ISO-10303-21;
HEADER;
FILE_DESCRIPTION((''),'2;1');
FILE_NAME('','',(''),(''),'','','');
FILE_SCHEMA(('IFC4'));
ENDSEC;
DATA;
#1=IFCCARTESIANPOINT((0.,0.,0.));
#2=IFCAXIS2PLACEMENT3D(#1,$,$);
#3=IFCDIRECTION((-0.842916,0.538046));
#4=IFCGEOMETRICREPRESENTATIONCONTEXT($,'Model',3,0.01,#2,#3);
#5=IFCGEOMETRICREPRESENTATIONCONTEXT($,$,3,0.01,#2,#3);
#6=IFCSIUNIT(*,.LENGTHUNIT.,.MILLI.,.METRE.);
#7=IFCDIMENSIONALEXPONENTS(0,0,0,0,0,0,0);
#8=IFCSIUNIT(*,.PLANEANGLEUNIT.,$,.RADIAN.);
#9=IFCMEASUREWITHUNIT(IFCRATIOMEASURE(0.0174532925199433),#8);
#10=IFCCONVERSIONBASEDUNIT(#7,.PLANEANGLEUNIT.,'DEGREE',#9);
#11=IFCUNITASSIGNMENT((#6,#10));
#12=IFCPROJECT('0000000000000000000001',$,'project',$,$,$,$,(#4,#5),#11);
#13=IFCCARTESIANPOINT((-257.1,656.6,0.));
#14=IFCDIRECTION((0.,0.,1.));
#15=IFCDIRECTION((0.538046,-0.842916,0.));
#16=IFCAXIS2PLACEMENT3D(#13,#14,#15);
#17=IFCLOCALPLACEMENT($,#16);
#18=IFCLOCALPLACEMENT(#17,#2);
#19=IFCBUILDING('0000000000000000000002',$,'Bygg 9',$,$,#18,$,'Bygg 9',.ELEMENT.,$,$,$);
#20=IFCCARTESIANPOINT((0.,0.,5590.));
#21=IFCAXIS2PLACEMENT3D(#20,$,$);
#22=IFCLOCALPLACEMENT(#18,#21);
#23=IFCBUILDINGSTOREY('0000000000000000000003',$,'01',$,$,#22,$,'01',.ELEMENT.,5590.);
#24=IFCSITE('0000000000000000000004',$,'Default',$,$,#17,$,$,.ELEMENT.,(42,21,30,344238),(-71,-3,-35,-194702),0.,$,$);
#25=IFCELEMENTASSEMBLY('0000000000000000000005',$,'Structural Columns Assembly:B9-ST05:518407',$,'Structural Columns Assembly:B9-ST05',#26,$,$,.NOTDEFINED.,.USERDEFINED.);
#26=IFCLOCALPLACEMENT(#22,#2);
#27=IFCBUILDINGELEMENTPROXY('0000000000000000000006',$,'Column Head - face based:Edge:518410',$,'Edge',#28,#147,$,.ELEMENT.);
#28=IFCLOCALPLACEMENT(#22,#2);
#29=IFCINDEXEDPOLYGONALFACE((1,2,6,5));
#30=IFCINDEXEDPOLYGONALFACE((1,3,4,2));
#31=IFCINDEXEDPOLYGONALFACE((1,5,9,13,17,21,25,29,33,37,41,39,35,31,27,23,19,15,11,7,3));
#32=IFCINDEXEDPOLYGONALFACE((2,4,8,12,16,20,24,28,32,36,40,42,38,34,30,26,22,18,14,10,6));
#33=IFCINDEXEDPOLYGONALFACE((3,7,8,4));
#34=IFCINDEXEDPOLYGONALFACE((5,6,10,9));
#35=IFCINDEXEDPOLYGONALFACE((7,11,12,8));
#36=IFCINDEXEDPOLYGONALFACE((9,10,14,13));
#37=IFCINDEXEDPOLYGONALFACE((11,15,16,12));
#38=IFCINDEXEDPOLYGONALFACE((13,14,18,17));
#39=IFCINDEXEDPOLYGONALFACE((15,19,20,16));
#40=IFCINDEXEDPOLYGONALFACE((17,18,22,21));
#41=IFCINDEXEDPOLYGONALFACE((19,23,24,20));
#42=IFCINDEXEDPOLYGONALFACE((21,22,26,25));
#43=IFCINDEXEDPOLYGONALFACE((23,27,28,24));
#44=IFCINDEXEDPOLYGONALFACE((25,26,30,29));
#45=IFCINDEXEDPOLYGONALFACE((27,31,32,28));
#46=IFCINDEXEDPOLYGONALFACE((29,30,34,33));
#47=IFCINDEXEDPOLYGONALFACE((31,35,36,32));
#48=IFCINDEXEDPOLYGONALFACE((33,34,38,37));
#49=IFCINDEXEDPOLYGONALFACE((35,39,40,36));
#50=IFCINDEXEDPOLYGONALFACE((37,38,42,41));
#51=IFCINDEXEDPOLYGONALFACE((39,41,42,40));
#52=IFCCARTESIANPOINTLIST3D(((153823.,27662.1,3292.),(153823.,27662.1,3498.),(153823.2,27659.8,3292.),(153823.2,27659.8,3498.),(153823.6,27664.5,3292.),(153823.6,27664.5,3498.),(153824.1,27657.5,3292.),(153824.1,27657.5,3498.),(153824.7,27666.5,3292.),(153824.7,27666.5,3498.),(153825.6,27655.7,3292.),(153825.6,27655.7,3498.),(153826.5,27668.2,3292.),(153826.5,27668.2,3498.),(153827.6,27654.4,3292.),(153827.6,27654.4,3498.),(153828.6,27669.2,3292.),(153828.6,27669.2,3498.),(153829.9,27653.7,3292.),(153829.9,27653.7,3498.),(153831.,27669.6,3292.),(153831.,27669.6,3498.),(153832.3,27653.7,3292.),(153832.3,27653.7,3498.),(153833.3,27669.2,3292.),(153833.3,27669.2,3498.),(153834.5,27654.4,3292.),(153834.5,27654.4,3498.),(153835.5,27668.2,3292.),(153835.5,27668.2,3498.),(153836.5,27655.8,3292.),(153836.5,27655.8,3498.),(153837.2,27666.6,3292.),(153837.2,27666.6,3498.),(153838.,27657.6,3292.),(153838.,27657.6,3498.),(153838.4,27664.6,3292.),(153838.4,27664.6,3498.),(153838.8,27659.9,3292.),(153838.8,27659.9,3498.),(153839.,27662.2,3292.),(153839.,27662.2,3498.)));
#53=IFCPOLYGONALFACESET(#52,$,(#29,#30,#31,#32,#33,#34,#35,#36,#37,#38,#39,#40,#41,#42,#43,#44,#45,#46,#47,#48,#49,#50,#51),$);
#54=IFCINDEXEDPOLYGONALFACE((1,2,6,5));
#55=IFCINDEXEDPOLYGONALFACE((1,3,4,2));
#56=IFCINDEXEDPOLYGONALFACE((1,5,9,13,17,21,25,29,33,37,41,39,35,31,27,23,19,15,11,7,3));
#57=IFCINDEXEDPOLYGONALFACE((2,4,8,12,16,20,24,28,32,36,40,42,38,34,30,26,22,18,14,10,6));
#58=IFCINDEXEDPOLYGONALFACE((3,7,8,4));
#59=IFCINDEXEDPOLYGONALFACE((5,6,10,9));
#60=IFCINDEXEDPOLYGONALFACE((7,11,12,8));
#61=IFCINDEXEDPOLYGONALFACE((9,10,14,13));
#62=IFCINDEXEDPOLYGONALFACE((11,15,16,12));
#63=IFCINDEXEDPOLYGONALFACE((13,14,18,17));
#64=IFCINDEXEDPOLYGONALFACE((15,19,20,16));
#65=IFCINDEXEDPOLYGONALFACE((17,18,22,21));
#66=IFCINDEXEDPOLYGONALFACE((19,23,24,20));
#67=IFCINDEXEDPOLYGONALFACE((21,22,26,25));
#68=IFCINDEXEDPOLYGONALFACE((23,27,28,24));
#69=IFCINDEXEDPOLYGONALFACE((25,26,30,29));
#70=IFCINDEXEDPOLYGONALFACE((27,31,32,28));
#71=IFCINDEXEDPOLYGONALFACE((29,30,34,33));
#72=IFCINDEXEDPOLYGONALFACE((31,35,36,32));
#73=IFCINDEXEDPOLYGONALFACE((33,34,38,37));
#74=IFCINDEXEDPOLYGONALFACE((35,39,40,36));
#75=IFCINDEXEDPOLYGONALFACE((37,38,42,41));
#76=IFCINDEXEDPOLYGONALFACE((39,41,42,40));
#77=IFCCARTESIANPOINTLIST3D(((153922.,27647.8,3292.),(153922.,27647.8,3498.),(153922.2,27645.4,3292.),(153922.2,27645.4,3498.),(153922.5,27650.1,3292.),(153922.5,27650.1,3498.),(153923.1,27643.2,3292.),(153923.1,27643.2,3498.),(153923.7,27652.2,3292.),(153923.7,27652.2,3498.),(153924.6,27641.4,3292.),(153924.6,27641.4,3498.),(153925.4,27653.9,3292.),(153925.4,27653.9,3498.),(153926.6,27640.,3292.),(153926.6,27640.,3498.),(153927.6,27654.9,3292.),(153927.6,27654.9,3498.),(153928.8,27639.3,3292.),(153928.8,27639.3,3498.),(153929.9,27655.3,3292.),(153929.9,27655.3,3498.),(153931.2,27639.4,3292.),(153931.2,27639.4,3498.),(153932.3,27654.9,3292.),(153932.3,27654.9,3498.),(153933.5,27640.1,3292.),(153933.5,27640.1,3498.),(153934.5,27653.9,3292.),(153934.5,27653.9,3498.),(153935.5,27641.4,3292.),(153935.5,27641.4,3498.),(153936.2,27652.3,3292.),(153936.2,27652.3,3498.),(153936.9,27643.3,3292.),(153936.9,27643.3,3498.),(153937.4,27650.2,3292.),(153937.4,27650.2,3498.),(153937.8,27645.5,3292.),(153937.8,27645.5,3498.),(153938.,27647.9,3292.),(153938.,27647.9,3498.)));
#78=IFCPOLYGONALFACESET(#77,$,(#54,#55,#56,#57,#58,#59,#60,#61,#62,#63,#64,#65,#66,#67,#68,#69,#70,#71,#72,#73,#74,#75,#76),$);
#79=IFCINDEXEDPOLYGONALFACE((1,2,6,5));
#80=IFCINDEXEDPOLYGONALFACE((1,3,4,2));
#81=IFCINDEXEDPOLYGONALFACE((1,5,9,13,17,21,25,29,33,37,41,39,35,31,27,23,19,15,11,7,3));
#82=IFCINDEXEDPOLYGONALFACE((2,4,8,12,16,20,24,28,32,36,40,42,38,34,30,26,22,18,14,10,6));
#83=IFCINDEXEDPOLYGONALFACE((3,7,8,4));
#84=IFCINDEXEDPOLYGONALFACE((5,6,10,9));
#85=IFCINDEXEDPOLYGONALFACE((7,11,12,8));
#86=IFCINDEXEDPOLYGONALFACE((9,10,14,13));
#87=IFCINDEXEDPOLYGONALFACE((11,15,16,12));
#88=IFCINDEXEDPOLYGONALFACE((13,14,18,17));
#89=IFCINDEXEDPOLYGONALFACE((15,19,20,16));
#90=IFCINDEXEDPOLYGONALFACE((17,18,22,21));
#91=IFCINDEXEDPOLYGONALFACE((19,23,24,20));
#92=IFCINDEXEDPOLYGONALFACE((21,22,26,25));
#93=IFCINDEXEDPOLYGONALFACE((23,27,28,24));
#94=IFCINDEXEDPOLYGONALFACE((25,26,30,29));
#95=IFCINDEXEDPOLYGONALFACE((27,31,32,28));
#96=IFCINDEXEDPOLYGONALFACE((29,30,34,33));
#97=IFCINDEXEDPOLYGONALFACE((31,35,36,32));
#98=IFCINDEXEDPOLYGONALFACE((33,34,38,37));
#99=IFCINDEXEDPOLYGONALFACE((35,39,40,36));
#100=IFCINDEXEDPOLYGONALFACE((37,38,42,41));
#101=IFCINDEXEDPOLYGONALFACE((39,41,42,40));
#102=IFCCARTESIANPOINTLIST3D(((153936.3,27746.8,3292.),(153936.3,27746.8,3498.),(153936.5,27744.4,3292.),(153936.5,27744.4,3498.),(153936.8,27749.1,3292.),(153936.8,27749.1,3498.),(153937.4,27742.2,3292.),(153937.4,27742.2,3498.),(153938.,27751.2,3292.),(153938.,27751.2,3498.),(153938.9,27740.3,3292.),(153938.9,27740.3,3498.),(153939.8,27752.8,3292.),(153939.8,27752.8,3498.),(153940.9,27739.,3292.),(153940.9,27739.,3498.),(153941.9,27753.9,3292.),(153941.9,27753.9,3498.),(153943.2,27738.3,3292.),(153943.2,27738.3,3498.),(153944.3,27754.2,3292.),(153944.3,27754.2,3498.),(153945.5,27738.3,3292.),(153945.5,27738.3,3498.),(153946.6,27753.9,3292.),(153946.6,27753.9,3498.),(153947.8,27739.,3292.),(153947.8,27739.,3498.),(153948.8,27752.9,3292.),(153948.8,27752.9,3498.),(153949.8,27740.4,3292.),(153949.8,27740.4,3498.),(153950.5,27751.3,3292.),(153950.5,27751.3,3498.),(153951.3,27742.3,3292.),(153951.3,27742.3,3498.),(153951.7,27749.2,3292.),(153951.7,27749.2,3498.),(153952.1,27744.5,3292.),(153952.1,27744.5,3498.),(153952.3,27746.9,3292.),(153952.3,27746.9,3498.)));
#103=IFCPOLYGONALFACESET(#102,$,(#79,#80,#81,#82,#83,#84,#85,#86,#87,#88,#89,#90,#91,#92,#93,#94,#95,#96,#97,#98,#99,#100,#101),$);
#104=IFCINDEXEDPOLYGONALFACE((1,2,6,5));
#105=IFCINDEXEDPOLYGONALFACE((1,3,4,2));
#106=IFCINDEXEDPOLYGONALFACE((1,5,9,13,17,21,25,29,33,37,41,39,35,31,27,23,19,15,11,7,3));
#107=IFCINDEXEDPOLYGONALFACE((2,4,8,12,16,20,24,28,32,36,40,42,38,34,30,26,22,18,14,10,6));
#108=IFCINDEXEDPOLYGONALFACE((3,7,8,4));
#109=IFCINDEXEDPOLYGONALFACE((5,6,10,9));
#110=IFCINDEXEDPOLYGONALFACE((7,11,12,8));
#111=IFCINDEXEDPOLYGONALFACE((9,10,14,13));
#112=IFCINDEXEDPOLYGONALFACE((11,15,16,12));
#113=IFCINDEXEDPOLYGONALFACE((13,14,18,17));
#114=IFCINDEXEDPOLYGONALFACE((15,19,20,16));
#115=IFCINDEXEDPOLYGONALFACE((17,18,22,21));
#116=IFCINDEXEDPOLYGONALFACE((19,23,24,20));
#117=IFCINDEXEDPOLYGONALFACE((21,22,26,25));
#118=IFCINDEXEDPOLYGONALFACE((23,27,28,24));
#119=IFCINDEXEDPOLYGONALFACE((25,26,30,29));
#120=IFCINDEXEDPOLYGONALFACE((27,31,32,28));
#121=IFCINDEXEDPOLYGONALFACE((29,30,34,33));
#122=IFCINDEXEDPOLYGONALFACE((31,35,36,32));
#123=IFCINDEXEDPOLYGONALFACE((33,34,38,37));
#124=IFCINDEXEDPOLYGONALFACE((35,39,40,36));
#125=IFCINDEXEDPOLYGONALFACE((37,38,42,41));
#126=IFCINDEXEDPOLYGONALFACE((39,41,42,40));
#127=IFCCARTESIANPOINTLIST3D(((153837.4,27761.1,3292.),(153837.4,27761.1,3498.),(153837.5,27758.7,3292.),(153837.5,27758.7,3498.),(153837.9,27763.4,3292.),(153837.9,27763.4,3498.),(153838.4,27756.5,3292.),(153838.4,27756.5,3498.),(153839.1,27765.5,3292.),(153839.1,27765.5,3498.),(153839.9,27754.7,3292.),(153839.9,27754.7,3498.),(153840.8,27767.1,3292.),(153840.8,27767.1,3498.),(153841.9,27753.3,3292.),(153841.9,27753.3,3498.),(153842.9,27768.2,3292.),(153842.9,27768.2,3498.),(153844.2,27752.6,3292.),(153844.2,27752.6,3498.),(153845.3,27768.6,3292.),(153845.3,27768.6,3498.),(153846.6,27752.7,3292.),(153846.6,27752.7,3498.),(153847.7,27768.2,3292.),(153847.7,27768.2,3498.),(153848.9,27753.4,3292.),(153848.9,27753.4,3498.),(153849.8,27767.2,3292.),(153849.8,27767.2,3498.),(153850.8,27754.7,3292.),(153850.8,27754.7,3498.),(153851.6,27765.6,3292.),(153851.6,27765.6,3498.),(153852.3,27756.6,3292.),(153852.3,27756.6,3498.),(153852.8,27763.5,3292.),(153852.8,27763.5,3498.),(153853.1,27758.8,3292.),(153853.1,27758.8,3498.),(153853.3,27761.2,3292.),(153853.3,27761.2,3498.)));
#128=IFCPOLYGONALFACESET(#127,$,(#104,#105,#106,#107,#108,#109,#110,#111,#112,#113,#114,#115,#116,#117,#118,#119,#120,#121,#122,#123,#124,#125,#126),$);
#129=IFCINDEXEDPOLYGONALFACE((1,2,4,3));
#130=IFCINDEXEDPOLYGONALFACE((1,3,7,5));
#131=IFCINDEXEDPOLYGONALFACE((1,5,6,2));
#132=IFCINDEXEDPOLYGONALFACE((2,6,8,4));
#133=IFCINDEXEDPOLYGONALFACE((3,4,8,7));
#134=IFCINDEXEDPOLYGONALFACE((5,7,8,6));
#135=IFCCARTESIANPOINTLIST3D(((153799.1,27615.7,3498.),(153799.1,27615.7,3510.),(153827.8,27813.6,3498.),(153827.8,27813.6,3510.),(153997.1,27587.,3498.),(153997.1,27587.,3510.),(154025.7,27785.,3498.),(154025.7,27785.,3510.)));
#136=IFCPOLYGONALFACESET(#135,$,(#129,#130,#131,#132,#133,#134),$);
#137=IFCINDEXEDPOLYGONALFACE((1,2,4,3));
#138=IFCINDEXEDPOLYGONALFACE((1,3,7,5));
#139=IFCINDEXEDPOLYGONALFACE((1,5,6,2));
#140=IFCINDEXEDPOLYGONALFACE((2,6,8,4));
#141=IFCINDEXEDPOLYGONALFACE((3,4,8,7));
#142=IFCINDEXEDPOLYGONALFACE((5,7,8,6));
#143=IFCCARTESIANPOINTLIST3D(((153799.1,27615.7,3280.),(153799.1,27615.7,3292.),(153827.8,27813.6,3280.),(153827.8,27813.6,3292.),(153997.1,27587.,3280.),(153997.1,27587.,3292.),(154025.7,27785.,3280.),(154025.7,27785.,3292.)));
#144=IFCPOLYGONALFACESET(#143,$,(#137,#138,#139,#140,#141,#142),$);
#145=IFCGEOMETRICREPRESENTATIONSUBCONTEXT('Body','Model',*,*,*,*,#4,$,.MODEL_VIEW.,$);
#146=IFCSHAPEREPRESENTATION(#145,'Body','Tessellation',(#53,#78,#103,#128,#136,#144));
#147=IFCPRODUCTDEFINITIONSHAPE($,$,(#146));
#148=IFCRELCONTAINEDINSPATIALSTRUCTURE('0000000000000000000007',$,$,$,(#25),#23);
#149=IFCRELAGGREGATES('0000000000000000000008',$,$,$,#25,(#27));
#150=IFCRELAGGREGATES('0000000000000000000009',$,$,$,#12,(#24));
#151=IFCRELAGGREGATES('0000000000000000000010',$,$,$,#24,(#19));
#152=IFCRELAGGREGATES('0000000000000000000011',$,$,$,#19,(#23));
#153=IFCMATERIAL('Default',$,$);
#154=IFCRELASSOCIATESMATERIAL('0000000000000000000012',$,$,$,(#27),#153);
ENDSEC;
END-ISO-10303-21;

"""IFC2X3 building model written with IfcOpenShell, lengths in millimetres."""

from ifc_helpers import new_model, entity, si_unit, converted_unit, direction, frame, frame_2d, origin, origin_2d_with_axis, place, context, subcontext, project, spatial, rectangle, circle, extrude, source, transform, mapped, material, element, aggregate, save


model = new_model("IFC2X3")

# Units and contexts
model_context = context("Model", 3, precision=0.01, world=origin(), true_north=direction((-0.842916, 0.538046)))
context_of_model = context(None, 3, precision=0.01, world=origin(), true_north=direction((-0.842916, 0.538046)))
body_context = subcontext(model_context, "Body", "Model", "MODEL_VIEW")
ifc_project = project(units=[si_unit("LENGTHUNIT", "METRE", prefix="MILLI"), converted_unit("PLANEANGLEUNIT", "DEGREE", entity("IfcRatioMeasure", 0.0174532925199433), si_unit("PLANEANGLEUNIT", "RADIAN"), dimensions=[0, 0, 0, 0, 0, 0, 0])], contexts=[model_context, context_of_model])

# Site, building, storey
site_placement = place(None, frame((-257.1, 656.6, 0.0), z_axis=(0.0, 0.0, 1.0), x_axis=(0.538046, -0.842916, 0.0)))
site = spatial("IfcSite", under=ifc_project, at=site_placement, Name="Default", CompositionType="ELEMENT", RefLatitude=(42, 21, 30, 344238), RefLongitude=(-71, -3, -35, -194702), RefElevation=0.0)
building_placement = place(site_placement, origin())
building = spatial("IfcBuilding", under=site, at=building_placement, Name="Bygg 9", LongName="Bygg 9", CompositionType="ELEMENT")
storey_placement = place(building_placement, frame((0.0, 0.0, 5590.0)))
storey = spatial("IfcBuildingStorey", under=building, at=storey_placement, Name="01", LongName="01", CompositionType="ELEMENT", Elevation=5590.0)

# Element assembly
assembly_1_placement = place(storey_placement, origin())
assembly_1 = element("IfcElementAssembly", 1, at=assembly_1_placement, inside=storey, Name="Structural Columns Assembly:B9-ST05:518407", ObjectType="Structural Columns Assembly:B9-ST05", AssemblyPlace="NOTDEFINED", PredefinedType="USERDEFINED")

# Building element proxy
ifc_material_1 = material(Name="Default")
shared_shape_1 = source(origin(), body_context, "Body", "SweptSolid", [
    extrude(circle(Radius=8.0, at=frame_2d((0.0, 0.0), x_axis=(1.0, 0.0))), frame((50.0, -75.0, 12.0)), (0.0, 0.0, 1.0), 206.0),
    extrude(circle(Radius=8.0, at=frame_2d((0.0, 0.0), x_axis=(1.0, 0.0))), frame((50.0, 25.0, 12.0)), (0.0, 0.0, 1.0), 206.0),
    extrude(circle(Radius=8.0, at=frame_2d((0.0, 0.0), x_axis=(1.0, 0.0))), frame((-50.0, 25.0, 12.0)), (0.0, 0.0, 1.0), 206.0),
    extrude(circle(Radius=8.0, at=frame_2d((0.0, 0.0), x_axis=(1.0, 0.0))), frame((-50.0, -75.0, 12.0)), (0.0, 0.0, 1.0), 206.0),
    extrude(rectangle(XDim=200.0, YDim=200.0, at=origin_2d_with_axis()), frame((0.0, 0.0, 218.0), z_axis=(0.0, 0.0, 1.0), x_axis=(-1.0, 0.0, 0.0)), (0.0, 0.0, 1.0), 12.0),
    extrude(rectangle(XDim=200.0, YDim=200.0, at=origin_2d_with_axis()), frame((0.0, 0.0, 0.0), z_axis=(0.0, 0.0, 1.0), x_axis=(0.0, 1.0, 0.0)), (0.0, 0.0, 1.0), 12.0),
])
proxy_1_placement = place(assembly_1_placement, frame((153912.4, 27700.3, 3280.0), z_axis=(0.0, 0.0, 1.0), x_axis=(-0.143216, -0.989691, 0.0)))
proxy_1 = element("IfcBuildingElementProxy", 2, at=proxy_1_placement, material=ifc_material_1, Name="Column Head - face based:Edge:518410", ObjectType="Edge", CompositionType="ELEMENT", context=body_context, shape_type="MappedRepresentation", body=[
    mapped(shared_shape_1, transform((0.0, 0.0, 0.0), scale=1.0)),
])
aggregate(assembly_1, [proxy_1])

save(model, "model.ifc")
